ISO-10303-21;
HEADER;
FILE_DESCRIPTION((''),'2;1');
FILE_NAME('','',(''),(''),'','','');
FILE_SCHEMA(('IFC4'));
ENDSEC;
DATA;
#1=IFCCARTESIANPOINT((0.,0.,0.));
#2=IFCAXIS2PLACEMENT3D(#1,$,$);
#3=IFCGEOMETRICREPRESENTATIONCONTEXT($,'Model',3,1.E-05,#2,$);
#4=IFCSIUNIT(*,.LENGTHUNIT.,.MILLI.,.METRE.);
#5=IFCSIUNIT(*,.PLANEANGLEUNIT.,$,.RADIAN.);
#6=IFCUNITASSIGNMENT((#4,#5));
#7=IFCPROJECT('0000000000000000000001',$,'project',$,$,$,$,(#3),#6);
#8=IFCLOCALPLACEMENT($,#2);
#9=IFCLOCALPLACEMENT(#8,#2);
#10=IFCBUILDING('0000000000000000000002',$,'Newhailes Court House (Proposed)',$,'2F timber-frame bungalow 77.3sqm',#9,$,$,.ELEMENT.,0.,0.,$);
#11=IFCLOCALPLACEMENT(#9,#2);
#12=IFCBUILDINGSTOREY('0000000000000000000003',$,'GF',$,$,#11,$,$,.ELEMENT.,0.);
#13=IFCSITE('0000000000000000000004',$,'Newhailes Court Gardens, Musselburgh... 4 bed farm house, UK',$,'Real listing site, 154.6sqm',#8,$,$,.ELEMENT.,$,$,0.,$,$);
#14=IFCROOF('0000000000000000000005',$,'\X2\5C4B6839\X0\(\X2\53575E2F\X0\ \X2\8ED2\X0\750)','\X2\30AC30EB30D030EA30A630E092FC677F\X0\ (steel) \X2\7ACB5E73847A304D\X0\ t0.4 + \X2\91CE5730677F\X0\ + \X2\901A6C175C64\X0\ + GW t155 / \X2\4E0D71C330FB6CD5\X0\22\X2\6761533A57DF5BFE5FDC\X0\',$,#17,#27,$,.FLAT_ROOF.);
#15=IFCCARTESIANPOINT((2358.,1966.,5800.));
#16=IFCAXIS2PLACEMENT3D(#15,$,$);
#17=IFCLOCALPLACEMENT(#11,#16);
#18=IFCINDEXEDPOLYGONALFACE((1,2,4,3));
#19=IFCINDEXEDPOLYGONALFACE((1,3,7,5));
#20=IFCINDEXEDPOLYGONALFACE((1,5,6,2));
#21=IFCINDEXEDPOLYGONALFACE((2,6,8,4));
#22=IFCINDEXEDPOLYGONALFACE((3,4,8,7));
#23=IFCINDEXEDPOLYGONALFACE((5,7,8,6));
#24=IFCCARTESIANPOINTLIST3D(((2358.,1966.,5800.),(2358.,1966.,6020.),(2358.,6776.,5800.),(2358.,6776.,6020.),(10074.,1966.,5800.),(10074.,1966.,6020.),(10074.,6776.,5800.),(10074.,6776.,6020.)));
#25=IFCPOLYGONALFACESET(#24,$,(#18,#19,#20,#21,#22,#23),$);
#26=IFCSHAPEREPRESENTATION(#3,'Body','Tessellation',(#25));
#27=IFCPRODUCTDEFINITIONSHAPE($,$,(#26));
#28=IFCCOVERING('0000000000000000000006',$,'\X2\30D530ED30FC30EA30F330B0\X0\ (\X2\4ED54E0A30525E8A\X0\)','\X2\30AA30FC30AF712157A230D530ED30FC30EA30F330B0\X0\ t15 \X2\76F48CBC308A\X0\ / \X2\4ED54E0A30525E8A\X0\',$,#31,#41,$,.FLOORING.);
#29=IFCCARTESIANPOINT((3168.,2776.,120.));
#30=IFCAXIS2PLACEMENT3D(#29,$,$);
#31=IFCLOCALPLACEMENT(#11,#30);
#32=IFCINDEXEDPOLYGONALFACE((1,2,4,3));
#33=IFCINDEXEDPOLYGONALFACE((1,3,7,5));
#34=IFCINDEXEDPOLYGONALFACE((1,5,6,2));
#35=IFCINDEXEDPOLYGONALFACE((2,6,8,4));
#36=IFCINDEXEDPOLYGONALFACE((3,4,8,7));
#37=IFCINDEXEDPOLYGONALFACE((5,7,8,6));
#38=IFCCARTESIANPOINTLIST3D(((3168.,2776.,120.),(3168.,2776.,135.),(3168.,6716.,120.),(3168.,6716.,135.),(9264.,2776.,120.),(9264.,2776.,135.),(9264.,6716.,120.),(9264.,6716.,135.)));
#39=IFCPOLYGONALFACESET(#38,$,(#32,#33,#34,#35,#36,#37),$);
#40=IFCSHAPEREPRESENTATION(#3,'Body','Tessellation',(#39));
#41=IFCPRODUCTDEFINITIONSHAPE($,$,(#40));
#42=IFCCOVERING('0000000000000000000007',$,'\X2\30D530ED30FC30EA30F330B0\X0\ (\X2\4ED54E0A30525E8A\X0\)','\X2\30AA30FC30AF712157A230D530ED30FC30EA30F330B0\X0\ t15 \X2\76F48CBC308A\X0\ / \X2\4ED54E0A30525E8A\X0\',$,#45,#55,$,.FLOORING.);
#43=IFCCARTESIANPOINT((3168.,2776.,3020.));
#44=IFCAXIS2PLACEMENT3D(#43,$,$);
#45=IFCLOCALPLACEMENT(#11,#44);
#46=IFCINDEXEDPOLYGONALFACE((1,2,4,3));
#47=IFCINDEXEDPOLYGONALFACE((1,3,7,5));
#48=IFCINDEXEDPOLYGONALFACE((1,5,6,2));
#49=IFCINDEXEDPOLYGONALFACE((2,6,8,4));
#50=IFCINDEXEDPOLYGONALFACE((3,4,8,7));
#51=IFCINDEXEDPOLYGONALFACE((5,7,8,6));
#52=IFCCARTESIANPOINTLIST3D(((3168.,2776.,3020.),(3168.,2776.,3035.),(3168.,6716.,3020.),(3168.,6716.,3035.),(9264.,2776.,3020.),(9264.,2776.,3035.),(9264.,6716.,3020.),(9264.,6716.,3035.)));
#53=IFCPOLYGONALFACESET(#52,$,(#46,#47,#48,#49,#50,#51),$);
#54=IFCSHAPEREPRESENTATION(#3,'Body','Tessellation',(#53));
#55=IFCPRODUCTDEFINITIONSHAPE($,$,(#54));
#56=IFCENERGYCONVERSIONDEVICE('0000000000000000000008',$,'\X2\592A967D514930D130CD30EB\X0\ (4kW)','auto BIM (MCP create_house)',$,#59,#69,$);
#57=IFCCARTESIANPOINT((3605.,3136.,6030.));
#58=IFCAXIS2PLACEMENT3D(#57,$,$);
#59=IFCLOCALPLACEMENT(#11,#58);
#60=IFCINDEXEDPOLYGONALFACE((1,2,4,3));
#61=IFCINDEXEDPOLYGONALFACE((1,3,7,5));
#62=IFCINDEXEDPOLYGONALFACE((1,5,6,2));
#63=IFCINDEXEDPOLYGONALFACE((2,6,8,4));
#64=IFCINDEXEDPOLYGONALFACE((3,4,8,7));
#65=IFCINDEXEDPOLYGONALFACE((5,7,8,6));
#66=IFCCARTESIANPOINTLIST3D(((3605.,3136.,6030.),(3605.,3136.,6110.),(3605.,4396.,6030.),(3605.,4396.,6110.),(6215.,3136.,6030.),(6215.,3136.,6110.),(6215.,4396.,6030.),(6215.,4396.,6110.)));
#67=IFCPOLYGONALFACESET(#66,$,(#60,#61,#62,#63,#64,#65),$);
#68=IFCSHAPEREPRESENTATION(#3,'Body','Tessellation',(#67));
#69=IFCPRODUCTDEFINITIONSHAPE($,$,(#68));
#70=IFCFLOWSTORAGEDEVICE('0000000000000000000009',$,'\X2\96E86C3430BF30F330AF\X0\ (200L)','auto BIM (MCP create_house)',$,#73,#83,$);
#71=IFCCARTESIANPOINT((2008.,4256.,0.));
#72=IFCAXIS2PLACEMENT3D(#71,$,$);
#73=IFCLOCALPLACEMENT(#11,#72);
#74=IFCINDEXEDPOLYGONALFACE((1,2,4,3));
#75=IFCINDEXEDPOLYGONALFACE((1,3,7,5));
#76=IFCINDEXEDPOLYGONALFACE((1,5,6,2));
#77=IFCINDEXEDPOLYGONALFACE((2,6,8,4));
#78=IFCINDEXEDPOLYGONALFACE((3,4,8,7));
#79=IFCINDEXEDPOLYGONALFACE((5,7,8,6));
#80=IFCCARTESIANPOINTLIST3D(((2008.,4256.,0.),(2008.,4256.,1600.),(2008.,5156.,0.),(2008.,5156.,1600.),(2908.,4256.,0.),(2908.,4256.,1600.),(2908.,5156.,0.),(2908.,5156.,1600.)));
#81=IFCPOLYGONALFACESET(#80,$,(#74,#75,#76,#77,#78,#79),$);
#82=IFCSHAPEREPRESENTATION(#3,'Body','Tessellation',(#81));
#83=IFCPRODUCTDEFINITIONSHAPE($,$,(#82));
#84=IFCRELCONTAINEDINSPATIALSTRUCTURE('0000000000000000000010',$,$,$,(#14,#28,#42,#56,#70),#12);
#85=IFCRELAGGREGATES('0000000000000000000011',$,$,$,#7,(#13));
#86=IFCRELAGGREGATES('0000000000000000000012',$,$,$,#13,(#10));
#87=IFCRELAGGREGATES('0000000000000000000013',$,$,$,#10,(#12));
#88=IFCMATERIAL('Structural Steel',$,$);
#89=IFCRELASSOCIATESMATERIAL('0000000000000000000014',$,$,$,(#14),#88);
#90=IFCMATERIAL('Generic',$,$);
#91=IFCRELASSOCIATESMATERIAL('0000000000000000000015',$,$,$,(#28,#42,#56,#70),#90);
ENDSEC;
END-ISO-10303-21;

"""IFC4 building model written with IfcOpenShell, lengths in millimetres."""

from ifc_helpers import new_model, si_unit, frame, frame_2d, origin, place, context, project, spatial, rectangle, extrude, material, element, save


model = new_model("IFC4")

# Units and contexts
model_context = context("Model", 3, precision=1e-05, world=origin())
ifc_project = project(units=[si_unit("LENGTHUNIT", "METRE", prefix="MILLI"), si_unit("PLANEANGLEUNIT", "RADIAN")], contexts=[model_context])

# Site, building, storey
site_placement = place(None, origin())
site = spatial("IfcSite", under=ifc_project, at=site_placement, Name="Newhailes Court Gardens, Musselburgh... 4 bed farm house, UK", ObjectType="Real listing site, 154.6sqm", CompositionType="ELEMENT", RefElevation=0.0)
building_placement = place(site_placement, origin())
building = spatial("IfcBuilding", under=site, at=building_placement, Name="Newhailes Court House (Proposed)", ObjectType="2F timber-frame bungalow 77.3sqm", CompositionType="ELEMENT", ElevationOfRefHeight=0.0, ElevationOfTerrain=0.0)
storey_placement = place(building_placement, origin())
storey = spatial("IfcBuildingStorey", under=building, at=storey_placement, Name="GF", CompositionType="ELEMENT", Elevation=0.0)

# Roof
ifc_material_1 = material(Name="Structural Steel")
for number, where, name in (
    (1, (2358.0, 1966.0, 5800.0), "屋根(南帯 軒750)"),
):
    element("IfcRoof", number, at=place(storey_placement, frame(where)), inside=storey, material=ifc_material_1, Name=name, Description="ガルバリウム鋼板 (steel) 立平葺き t0.4 + 野地板 + 通気層 + GW t155 / 不燃・法22条区域対応", PredefinedType="FLAT_ROOF", context=model_context, shape_type="SweptSolid", body=[
        extrude(rectangle(XDim=7716.0, YDim=4810.0, at=frame_2d((3858.0, 2405.0))), frame((2358.0, 1966.0, 5800.0)), (0.0, 0.0, 1.0), 220.0),
    ])

# Coverings
ifc_material_2 = material(Name="Generic")
covering_1_placement = place(storey_placement, frame((3168.0, 2776.0, 120.0)))
element("IfcCovering", 2, at=covering_1_placement, inside=storey, material=ifc_material_2, Name="フローリング (仕上げ床)", Description="オーク無垢フローリング t15 直貼り / 仕上げ床", PredefinedType="FLOORING", context=model_context, shape_type="SweptSolid", body=[
    extrude(rectangle(XDim=6096.0, YDim=3940.0, at=frame_2d((3048.0, 1970.0))), frame((3168.0, 2776.0, 120.0)), (0.0, 0.0, 1.0), 15.0),
])
covering_2_placement = place(storey_placement, frame((3168.0, 2776.0, 3020.0)))
element("IfcCovering", 3, at=covering_2_placement, inside=storey, material=ifc_material_2, Name="フローリング (仕上げ床)", Description="オーク無垢フローリング t15 直貼り / 仕上げ床", PredefinedType="FLOORING", context=model_context, shape_type="SweptSolid", body=[
    extrude(rectangle(XDim=6096.0, YDim=3940.0, at=frame_2d((3048.0, 1970.0))), frame((3168.0, 2776.0, 3020.0)), (0.0, 0.0, 1.0), 15.0),
])

# Energy conversion device
energy_conversion_device_placement = place(storey_placement, frame((3605.0, 3136.0, 6030.0)))
element("IfcEnergyConversionDevice", 4, at=energy_conversion_device_placement, inside=storey, material=ifc_material_2, Name="太陽光パネル (4kW)", Description="auto BIM (MCP create_house)", context=model_context, shape_type="SweptSolid", body=[
    extrude(rectangle(XDim=2610.0, YDim=1260.0, at=frame_2d((1305.0, 630.0))), frame((3605.0, 3136.0, 6030.0)), (0.0, 0.0, 1.0), 80.0),
])

# Flow storage device
flow_storage_device_placement = place(storey_placement, frame((2008.0, 4256.0, 0.0)))
element("IfcFlowStorageDevice", 5, at=flow_storage_device_placement, inside=storey, material=ifc_material_2, Name="雨水タンク (200L)", Description="auto BIM (MCP create_house)", context=model_context, shape_type="SweptSolid", body=[
    extrude(rectangle(XDim=900.0, YDim=900.0, at=frame_2d((450.0, 450.0))), frame((2008.0, 4256.0, 0.0)), (0.0, 0.0, 1.0), 1600.0),
])

save(model, "model.ifc")
